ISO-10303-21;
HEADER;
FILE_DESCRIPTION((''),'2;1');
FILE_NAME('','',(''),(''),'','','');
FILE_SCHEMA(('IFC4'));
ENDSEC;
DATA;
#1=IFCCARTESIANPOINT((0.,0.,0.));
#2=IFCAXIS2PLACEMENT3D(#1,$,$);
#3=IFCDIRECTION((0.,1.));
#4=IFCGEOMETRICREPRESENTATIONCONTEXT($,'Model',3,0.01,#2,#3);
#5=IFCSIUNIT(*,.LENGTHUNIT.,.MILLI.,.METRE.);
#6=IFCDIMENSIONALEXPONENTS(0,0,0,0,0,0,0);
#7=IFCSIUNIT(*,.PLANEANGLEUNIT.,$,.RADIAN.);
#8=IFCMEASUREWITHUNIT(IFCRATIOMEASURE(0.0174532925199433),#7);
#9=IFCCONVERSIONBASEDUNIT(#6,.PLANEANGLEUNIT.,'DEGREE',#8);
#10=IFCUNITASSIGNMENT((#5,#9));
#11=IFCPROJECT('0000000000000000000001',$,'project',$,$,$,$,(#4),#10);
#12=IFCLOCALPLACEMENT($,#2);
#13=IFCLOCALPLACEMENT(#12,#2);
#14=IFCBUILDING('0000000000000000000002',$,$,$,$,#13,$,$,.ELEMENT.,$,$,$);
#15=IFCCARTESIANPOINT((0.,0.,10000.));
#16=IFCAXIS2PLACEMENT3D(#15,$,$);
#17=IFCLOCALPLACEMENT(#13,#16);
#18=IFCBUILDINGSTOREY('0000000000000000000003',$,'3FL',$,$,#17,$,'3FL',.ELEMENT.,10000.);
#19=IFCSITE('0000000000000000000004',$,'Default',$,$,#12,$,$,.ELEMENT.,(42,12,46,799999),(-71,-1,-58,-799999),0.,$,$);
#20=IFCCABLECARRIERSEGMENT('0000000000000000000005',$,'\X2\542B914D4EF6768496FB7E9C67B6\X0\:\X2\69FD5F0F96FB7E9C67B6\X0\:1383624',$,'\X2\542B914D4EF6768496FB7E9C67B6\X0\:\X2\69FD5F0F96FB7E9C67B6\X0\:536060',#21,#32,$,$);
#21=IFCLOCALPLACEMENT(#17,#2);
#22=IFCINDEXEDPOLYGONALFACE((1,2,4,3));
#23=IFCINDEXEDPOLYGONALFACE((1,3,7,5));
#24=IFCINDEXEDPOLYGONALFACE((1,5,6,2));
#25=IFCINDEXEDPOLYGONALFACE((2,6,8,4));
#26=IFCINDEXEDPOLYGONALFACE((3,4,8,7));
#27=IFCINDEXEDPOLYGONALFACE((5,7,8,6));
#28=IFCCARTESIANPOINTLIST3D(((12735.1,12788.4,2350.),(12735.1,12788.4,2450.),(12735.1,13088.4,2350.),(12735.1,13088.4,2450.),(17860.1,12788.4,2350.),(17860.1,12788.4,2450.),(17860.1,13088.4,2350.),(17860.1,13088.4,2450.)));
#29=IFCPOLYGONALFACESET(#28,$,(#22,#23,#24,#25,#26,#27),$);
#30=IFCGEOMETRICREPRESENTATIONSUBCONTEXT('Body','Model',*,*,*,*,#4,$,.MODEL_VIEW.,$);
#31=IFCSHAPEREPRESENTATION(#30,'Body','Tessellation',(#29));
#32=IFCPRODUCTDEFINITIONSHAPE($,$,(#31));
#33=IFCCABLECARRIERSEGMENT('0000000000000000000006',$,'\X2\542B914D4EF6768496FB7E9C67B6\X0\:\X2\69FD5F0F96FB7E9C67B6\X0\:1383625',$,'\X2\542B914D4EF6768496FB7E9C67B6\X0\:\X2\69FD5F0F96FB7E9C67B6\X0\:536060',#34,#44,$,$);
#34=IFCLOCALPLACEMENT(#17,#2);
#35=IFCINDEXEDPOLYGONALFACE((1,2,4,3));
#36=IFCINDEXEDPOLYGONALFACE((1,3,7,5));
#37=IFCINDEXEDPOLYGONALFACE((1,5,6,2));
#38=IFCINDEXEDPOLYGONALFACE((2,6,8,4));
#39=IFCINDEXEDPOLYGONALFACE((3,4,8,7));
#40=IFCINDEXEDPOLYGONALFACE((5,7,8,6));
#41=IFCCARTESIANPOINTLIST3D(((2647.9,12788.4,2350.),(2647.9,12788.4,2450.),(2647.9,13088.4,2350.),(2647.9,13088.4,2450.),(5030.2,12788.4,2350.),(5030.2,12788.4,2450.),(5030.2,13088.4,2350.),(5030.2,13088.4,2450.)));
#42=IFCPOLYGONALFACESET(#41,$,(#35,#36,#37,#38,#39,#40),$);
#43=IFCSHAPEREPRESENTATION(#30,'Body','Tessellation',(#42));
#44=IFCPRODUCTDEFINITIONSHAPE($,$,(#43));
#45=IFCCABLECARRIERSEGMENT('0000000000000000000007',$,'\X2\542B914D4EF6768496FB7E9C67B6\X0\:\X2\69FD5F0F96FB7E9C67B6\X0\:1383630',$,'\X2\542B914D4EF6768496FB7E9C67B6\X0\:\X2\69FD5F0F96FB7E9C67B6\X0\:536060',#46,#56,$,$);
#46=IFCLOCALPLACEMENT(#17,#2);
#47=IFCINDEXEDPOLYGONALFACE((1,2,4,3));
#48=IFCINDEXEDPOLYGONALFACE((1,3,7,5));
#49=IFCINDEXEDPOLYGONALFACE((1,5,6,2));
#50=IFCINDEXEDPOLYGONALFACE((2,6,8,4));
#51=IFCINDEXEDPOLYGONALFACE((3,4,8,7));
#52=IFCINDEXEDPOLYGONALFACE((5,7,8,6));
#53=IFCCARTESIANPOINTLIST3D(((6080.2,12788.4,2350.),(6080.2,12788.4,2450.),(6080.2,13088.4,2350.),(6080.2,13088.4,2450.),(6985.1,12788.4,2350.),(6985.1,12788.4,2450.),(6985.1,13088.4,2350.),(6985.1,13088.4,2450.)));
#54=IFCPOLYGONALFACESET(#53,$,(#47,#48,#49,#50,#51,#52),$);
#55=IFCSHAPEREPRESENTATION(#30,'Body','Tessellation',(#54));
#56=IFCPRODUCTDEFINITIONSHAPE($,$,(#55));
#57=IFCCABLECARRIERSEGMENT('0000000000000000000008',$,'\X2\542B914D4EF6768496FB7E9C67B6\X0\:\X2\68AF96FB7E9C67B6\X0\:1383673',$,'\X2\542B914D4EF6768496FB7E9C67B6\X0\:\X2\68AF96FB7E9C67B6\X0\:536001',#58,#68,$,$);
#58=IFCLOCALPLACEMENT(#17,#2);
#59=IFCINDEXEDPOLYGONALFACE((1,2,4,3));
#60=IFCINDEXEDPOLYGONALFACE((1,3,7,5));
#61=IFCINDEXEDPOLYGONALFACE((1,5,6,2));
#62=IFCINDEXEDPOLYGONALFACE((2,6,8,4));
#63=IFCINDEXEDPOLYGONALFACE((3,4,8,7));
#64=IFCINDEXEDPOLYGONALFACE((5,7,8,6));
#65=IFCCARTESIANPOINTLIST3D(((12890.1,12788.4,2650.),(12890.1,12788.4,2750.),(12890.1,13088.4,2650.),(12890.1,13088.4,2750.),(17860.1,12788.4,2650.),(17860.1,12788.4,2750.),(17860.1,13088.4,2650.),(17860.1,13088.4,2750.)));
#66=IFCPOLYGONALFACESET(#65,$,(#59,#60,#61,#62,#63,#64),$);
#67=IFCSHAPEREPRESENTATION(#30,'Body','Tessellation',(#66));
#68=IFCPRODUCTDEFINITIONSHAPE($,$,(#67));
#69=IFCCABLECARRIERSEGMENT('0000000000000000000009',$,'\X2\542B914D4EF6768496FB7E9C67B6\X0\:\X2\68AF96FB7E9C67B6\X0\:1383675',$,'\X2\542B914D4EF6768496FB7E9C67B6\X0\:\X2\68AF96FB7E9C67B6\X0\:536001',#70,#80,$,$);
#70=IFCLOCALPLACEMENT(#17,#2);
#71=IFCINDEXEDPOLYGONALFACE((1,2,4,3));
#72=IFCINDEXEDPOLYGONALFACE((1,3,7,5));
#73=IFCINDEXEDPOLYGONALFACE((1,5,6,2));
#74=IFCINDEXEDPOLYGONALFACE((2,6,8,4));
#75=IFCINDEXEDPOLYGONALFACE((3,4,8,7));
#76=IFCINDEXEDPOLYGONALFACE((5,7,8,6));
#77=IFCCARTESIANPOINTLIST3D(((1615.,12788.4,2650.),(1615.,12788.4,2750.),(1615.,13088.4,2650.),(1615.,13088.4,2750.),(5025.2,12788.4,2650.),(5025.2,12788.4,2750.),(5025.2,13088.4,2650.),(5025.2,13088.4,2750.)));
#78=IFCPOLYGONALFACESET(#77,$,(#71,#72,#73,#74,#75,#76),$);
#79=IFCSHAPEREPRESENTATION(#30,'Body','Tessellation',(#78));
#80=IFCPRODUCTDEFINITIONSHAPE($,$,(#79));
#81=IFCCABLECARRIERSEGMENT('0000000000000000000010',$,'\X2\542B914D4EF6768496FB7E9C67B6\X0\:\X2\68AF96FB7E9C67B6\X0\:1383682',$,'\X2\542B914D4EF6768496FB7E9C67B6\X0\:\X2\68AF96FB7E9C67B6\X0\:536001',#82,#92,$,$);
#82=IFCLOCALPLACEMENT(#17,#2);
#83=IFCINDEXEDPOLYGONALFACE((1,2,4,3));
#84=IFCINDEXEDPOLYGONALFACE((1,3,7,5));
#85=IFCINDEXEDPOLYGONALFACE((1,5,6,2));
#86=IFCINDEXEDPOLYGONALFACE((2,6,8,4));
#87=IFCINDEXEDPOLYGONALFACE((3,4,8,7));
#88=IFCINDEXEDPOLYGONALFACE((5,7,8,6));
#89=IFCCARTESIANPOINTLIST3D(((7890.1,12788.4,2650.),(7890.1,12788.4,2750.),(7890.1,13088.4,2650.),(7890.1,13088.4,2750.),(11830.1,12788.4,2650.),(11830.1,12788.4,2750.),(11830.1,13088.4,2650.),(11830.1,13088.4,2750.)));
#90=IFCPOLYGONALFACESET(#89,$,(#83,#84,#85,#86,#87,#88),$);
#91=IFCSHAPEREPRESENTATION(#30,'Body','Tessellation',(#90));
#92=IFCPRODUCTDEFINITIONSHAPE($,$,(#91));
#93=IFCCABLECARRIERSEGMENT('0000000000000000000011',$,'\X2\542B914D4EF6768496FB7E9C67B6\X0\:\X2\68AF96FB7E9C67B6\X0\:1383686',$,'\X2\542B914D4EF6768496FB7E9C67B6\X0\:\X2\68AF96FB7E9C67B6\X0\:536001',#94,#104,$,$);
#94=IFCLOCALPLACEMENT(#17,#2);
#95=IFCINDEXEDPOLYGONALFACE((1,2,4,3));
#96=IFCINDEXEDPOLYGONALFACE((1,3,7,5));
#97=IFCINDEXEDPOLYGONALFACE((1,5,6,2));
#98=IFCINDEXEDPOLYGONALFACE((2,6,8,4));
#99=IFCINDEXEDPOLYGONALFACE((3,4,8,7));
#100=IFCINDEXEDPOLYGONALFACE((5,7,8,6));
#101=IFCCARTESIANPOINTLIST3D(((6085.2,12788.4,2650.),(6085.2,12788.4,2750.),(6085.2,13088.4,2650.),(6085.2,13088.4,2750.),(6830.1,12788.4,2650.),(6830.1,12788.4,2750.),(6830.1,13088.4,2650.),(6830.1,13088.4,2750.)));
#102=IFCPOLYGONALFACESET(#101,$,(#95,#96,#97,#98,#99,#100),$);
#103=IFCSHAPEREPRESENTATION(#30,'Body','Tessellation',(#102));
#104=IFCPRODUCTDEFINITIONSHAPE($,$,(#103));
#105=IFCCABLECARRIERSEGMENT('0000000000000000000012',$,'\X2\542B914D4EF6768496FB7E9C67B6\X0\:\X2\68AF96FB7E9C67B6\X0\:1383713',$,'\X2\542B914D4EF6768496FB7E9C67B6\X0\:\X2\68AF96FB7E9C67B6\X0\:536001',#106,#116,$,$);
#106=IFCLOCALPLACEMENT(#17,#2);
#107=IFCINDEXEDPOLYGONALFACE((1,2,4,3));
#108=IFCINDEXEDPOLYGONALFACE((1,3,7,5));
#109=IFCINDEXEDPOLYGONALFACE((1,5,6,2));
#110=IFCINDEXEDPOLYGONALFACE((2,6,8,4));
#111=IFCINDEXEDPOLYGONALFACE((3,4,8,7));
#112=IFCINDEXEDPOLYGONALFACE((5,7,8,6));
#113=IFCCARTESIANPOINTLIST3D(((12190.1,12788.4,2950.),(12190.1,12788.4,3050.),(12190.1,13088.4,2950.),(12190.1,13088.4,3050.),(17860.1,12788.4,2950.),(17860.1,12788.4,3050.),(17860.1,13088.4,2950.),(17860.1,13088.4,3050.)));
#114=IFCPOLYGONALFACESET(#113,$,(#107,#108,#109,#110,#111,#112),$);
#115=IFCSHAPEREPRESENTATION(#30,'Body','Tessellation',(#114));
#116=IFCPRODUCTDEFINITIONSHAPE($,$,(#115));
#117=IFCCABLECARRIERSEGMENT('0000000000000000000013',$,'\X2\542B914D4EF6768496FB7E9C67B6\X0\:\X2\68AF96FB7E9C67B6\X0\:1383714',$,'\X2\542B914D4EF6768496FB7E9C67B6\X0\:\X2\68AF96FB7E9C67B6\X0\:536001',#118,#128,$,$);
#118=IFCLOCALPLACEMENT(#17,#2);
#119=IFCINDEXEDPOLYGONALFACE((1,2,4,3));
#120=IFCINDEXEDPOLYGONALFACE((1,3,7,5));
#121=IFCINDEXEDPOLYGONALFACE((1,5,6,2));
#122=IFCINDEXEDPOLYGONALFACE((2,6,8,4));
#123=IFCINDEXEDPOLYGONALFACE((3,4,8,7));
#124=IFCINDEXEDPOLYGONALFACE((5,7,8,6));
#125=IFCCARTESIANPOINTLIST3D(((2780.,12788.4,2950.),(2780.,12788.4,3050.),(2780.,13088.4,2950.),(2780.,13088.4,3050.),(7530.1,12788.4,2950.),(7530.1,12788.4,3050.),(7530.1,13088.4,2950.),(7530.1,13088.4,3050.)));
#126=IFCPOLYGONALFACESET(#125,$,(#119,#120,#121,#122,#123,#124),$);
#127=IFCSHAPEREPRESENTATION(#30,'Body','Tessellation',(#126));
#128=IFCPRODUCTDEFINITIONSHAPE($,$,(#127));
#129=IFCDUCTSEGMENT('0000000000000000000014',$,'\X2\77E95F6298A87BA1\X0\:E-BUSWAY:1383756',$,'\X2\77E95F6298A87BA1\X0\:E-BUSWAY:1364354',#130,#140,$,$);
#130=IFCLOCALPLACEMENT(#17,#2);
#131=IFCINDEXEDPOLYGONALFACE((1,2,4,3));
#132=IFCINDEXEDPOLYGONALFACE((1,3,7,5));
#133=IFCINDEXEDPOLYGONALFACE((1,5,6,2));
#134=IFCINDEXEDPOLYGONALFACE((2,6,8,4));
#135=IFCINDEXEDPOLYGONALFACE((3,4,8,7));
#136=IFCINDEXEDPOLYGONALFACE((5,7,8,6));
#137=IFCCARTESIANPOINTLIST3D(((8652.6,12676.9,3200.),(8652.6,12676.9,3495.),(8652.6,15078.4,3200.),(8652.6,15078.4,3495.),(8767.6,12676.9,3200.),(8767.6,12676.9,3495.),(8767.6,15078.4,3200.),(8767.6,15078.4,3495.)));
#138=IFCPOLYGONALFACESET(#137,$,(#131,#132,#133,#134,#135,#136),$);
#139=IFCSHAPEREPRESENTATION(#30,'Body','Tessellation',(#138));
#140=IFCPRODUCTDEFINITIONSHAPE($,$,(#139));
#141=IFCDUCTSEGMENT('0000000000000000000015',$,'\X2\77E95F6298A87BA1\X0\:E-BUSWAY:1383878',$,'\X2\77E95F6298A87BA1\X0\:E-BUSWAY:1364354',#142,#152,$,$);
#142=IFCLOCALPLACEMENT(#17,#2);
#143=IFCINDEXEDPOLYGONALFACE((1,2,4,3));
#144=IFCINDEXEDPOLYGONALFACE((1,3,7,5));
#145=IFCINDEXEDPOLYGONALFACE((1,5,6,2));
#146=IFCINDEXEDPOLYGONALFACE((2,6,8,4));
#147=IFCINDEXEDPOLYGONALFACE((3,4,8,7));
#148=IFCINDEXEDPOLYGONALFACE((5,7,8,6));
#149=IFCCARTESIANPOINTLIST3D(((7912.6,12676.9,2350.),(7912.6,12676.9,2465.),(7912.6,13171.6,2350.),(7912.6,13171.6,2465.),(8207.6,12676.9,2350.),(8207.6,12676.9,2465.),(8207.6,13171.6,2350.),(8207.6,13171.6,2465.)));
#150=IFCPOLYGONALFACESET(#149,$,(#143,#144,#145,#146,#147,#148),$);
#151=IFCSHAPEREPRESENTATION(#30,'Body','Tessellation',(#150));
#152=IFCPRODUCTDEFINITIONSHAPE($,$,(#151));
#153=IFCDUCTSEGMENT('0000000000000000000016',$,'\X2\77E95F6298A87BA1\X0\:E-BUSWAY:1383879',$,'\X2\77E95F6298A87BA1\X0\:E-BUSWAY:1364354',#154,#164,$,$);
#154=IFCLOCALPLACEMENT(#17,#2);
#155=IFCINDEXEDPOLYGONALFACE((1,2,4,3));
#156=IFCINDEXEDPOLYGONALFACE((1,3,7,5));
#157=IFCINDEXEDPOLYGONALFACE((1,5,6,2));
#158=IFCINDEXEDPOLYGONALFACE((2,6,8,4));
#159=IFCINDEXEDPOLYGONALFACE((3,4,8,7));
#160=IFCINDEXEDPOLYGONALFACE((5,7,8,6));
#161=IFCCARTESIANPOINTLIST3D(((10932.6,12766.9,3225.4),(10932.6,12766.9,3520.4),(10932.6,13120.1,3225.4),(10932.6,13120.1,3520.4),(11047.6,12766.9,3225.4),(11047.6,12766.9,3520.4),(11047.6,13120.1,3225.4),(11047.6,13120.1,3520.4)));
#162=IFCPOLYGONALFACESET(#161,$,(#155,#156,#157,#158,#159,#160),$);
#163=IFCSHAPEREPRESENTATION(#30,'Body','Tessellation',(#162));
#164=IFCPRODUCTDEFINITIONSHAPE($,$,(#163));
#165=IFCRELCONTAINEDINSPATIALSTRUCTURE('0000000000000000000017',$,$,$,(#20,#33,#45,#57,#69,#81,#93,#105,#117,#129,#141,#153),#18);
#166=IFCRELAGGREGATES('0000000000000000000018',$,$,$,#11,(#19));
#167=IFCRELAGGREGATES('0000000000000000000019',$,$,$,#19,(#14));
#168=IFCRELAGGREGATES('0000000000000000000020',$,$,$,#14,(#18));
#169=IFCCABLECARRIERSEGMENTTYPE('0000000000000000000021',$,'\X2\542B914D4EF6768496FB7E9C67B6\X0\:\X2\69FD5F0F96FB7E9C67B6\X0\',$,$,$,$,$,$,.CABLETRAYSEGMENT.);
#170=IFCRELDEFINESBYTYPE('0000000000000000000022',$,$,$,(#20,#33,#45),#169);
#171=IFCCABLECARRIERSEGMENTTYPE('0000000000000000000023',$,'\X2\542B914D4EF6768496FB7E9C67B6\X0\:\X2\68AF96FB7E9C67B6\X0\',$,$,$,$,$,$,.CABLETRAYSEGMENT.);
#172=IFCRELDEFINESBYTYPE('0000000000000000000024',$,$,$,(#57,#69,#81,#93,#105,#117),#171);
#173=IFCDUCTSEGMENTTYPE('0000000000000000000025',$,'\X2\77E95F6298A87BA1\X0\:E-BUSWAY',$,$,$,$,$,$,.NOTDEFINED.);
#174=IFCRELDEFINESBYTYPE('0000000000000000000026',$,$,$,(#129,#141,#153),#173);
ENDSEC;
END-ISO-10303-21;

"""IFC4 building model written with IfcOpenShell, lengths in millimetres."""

from ifc_helpers import new_model, entity, si_unit, converted_unit, direction, frame, frame_2d, origin, origin_2d_with_axis, place, context, subcontext, project, spatial, rectangle, extrude, type_object, element, save


model = new_model("IFC4")

# Units and contexts
model_context = context("Model", 3, precision=0.01, world=origin(), true_north=direction((0.0, 1.0)))
body_context = subcontext(model_context, "Body", "Model", "MODEL_VIEW")
ifc_project = project(units=[si_unit("LENGTHUNIT", "METRE", prefix="MILLI"), converted_unit("PLANEANGLEUNIT", "DEGREE", entity("IfcRatioMeasure", 0.0174532925199433), si_unit("PLANEANGLEUNIT", "RADIAN"), dimensions=[0, 0, 0, 0, 0, 0, 0])], contexts=[model_context])

# Site, building, storey
site_placement = place(None, origin())
site = spatial("IfcSite", under=ifc_project, at=site_placement, Name="Default", CompositionType="ELEMENT", RefLatitude=(42, 12, 46, 799999), RefLongitude=(-71, -1, -58, -799999), RefElevation=0.0)
building_placement = place(site_placement, origin())
building = spatial("IfcBuilding", under=site, at=building_placement, CompositionType="ELEMENT")
storey_placement = place(building_placement, frame((0.0, 0.0, 10000.0)))
storey = spatial("IfcBuildingStorey", under=building, at=storey_placement, Name="3FL", LongName="3FL", CompositionType="ELEMENT", Elevation=10000.0)

# Cable carrier segments
cable_carrier_segment_type_1 = type_object("IfcCableCarrierSegmentType", Name="含配件的電纜架:槽式電纜架", PredefinedType="CABLETRAYSEGMENT")
cable_carrier_segment_1_placement = place(storey_placement, frame((12735.1, 12788.4, 2350.0)))
element("IfcCableCarrierSegment", 1, at=cable_carrier_segment_1_placement, inside=storey, type_object=cable_carrier_segment_type_1, Name="含配件的電纜架:槽式電纜架:1383624", ObjectType="含配件的電纜架:槽式電纜架:536060", context=body_context, shape_type="SweptSolid", body=[
    extrude(rectangle(XDim=5125.0, YDim=300.0, at=frame_2d((0.0, 0.0), x_axis=(1.0, 0.0))), frame((2562.5, 150.0, 0.0), z_axis=(0.0, 0.0, 1.0), x_axis=(-1.0, 0.0, 0.0)), (0.0, 0.0, 1.0), 100.0),
])
cable_carrier_segment_2_placement = place(storey_placement, frame((2647.9, 12788.4, 2350.0)))
element("IfcCableCarrierSegment", 2, at=cable_carrier_segment_2_placement, inside=storey, type_object=cable_carrier_segment_type_1, Name="含配件的電纜架:槽式電纜架:1383625", ObjectType="含配件的電纜架:槽式電纜架:536060", context=body_context, shape_type="SweptSolid", body=[
    extrude(rectangle(XDim=2382.4, YDim=300.0, at=frame_2d((0.0, 0.0), x_axis=(1.0, 0.0))), frame((1191.2, 150.0, 0.0), z_axis=(0.0, 0.0, 1.0), x_axis=(-1.0, 0.0, 0.0)), (0.0, 0.0, 1.0), 100.0),
])
cable_carrier_segment_3_placement = place(storey_placement, frame((6080.2, 12788.4, 2350.0)))
element("IfcCableCarrierSegment", 3, at=cable_carrier_segment_3_placement, inside=storey, type_object=cable_carrier_segment_type_1, Name="含配件的電纜架:槽式電纜架:1383630", ObjectType="含配件的電纜架:槽式電纜架:536060", context=body_context, shape_type="SweptSolid", body=[
    extrude(rectangle(XDim=904.9, YDim=300.0, at=frame_2d((0.0, 0.0), x_axis=(1.0, 0.0))), frame((452.4, 150.0, 0.0), z_axis=(0.0, 0.0, 1.0), x_axis=(-1.0, 0.0, 0.0)), (0.0, 0.0, 1.0), 100.0),
])
cable_carrier_segment_type_2 = type_object("IfcCableCarrierSegmentType", Name="含配件的電纜架:梯電纜架", PredefinedType="CABLETRAYSEGMENT")
cable_carrier_segment_4_placement = place(storey_placement, frame((12890.1, 12788.4, 2650.0)))
element("IfcCableCarrierSegment", 4, at=cable_carrier_segment_4_placement, inside=storey, type_object=cable_carrier_segment_type_2, Name="含配件的電纜架:梯電纜架:1383673", ObjectType="含配件的電纜架:梯電纜架:536001", context=body_context, shape_type="SweptSolid", body=[
    extrude(rectangle(XDim=4970.0, YDim=300.0, at=frame_2d((0.0, 0.0), x_axis=(1.0, 0.0))), frame((2485.0, 150.0, 0.0), z_axis=(0.0, 0.0, 1.0), x_axis=(-1.0, 0.0, 0.0)), (0.0, 0.0, 1.0), 100.0),
])
cable_carrier_segment_5_placement = place(storey_placement, frame((1615.0, 12788.4, 2650.0)))
element("IfcCableCarrierSegment", 5, at=cable_carrier_segment_5_placement, inside=storey, type_object=cable_carrier_segment_type_2, Name="含配件的電纜架:梯電纜架:1383675", ObjectType="含配件的電纜架:梯電纜架:536001", context=body_context, shape_type="SweptSolid", body=[
    extrude(rectangle(XDim=3410.2, YDim=300.0, at=origin_2d_with_axis()), frame((1705.1, 150.0, 0.0), z_axis=(0.0, 0.0, 1.0), x_axis=(-1.0, 0.0, 0.0)), (0.0, 0.0, 1.0), 100.0),
])
cable_carrier_segment_6_placement = place(storey_placement, frame((7890.1, 12788.4, 2650.0)))
element("IfcCableCarrierSegment", 6, at=cable_carrier_segment_6_placement, inside=storey, type_object=cable_carrier_segment_type_2, Name="含配件的電纜架:梯電纜架:1383682", ObjectType="含配件的電纜架:梯電纜架:536001", context=body_context, shape_type="SweptSolid", body=[
    extrude(rectangle(XDim=3940.0, YDim=300.0, at=frame_2d((0.0, 0.0), x_axis=(1.0, 0.0))), frame((1970.0, 150.0, 0.0), z_axis=(0.0, 0.0, 1.0), x_axis=(-1.0, 0.0, 0.0)), (0.0, 0.0, 1.0), 100.0),
])
cable_carrier_segment_7_placement = place(storey_placement, frame((6085.2, 12788.4, 2650.0)))
element("IfcCableCarrierSegment", 7, at=cable_carrier_segment_7_placement, inside=storey, type_object=cable_carrier_segment_type_2, Name="含配件的電纜架:梯電纜架:1383686", ObjectType="含配件的電纜架:梯電纜架:536001", context=body_context, shape_type="SweptSolid", body=[
    extrude(rectangle(XDim=744.9, YDim=300.0, at=frame_2d((0.0, 0.0), x_axis=(1.0, 0.0))), frame((372.4, 150.0, 0.0), z_axis=(0.0, 0.0, 1.0), x_axis=(-1.0, 0.0, 0.0)), (0.0, 0.0, 1.0), 100.0),
])
cable_carrier_segment_8_placement = place(storey_placement, frame((12190.1, 12788.4, 2950.0)))
element("IfcCableCarrierSegment", 8, at=cable_carrier_segment_8_placement, inside=storey, type_object=cable_carrier_segment_type_2, Name="含配件的電纜架:梯電纜架:1383713", ObjectType="含配件的電纜架:梯電纜架:536001", context=body_context, shape_type="SweptSolid", body=[
    extrude(rectangle(XDim=5670.0, YDim=300.0, at=frame_2d((0.0, 0.0), x_axis=(1.0, 0.0))), frame((2835.0, 150.0, 0.0), z_axis=(0.0, 0.0, 1.0), x_axis=(-1.0, 0.0, 0.0)), (0.0, 0.0, 1.0), 100.0),
])
cable_carrier_segment_9_placement = place(storey_placement, frame((2780.0, 12788.4, 2950.0)))
element("IfcCableCarrierSegment", 9, at=cable_carrier_segment_9_placement, inside=storey, type_object=cable_carrier_segment_type_2, Name="含配件的電纜架:梯電纜架:1383714", ObjectType="含配件的電纜架:梯電纜架:536001", context=body_context, shape_type="SweptSolid", body=[
    extrude(rectangle(XDim=4750.1, YDim=300.0, at=frame_2d((0.0, 0.0), x_axis=(1.0, 0.0))), frame((2375.0, 150.0, 0.0), z_axis=(0.0, 0.0, 1.0), x_axis=(-1.0, 0.0, 0.0)), (0.0, 0.0, 1.0), 100.0),
])

# Duct segments
duct_segment_type = type_object("IfcDuctSegmentType", Name="矩形風管:E-BUSWAY", PredefinedType="NOTDEFINED")
duct_segment_1_placement = place(storey_placement, frame((8652.6, 12676.9, 3200.0)))
element("IfcDuctSegment", 10, at=duct_segment_1_placement, inside=storey, type_object=duct_segment_type, Name="矩形風管:E-BUSWAY:1383756", ObjectType="矩形風管:E-BUSWAY:1364354", context=body_context, shape_type="SweptSolid", body=[
    extrude(rectangle(XDim=2401.5, YDim=115.0, at=frame_2d((0.0, 0.0), x_axis=(1.0, 0.0))), frame((57.5, 1200.8, 0.0), z_axis=(0.0, 0.0, 1.0), x_axis=(0.0, -1.0, 0.0)), (0.0, 0.0, 1.0), 295.0),
])
duct_segment_2_placement = place(storey_placement, frame((7912.6, 12676.9, 2350.0)))
element("IfcDuctSegment", 11, at=duct_segment_2_placement, inside=storey, type_object=duct_segment_type, Name="矩形風管:E-BUSWAY:1383878", ObjectType="矩形風管:E-BUSWAY:1364354", context=body_context, shape_type="SweptSolid", body=[
    extrude(rectangle(XDim=494.7, YDim=295.0, at=origin_2d_with_axis()), frame((147.5, 247.3, 0.0), z_axis=(0.0, 0.0, 1.0), x_axis=(0.0, 1.0, 0.0)), (0.0, 0.0, 1.0), 115.0),
])
duct_segment_3_placement = place(storey_placement, frame((10932.6, 12766.9, 3225.4)))
element("IfcDuctSegment", 12, at=duct_segment_3_placement, inside=storey, type_object=duct_segment_type, Name="矩形風管:E-BUSWAY:1383879", ObjectType="矩形風管:E-BUSWAY:1364354", context=body_context, shape_type="SweptSolid", body=[
    extrude(rectangle(XDim=353.2, YDim=115.0, at=frame_2d((0.0, 0.0), x_axis=(1.0, 0.0))), frame((57.5, 176.6, 0.0), z_axis=(0.0, 0.0, 1.0), x_axis=(0.0, -1.0, 0.0)), (0.0, 0.0, 1.0), 295.0),
])

save(model, "model.ifc")
